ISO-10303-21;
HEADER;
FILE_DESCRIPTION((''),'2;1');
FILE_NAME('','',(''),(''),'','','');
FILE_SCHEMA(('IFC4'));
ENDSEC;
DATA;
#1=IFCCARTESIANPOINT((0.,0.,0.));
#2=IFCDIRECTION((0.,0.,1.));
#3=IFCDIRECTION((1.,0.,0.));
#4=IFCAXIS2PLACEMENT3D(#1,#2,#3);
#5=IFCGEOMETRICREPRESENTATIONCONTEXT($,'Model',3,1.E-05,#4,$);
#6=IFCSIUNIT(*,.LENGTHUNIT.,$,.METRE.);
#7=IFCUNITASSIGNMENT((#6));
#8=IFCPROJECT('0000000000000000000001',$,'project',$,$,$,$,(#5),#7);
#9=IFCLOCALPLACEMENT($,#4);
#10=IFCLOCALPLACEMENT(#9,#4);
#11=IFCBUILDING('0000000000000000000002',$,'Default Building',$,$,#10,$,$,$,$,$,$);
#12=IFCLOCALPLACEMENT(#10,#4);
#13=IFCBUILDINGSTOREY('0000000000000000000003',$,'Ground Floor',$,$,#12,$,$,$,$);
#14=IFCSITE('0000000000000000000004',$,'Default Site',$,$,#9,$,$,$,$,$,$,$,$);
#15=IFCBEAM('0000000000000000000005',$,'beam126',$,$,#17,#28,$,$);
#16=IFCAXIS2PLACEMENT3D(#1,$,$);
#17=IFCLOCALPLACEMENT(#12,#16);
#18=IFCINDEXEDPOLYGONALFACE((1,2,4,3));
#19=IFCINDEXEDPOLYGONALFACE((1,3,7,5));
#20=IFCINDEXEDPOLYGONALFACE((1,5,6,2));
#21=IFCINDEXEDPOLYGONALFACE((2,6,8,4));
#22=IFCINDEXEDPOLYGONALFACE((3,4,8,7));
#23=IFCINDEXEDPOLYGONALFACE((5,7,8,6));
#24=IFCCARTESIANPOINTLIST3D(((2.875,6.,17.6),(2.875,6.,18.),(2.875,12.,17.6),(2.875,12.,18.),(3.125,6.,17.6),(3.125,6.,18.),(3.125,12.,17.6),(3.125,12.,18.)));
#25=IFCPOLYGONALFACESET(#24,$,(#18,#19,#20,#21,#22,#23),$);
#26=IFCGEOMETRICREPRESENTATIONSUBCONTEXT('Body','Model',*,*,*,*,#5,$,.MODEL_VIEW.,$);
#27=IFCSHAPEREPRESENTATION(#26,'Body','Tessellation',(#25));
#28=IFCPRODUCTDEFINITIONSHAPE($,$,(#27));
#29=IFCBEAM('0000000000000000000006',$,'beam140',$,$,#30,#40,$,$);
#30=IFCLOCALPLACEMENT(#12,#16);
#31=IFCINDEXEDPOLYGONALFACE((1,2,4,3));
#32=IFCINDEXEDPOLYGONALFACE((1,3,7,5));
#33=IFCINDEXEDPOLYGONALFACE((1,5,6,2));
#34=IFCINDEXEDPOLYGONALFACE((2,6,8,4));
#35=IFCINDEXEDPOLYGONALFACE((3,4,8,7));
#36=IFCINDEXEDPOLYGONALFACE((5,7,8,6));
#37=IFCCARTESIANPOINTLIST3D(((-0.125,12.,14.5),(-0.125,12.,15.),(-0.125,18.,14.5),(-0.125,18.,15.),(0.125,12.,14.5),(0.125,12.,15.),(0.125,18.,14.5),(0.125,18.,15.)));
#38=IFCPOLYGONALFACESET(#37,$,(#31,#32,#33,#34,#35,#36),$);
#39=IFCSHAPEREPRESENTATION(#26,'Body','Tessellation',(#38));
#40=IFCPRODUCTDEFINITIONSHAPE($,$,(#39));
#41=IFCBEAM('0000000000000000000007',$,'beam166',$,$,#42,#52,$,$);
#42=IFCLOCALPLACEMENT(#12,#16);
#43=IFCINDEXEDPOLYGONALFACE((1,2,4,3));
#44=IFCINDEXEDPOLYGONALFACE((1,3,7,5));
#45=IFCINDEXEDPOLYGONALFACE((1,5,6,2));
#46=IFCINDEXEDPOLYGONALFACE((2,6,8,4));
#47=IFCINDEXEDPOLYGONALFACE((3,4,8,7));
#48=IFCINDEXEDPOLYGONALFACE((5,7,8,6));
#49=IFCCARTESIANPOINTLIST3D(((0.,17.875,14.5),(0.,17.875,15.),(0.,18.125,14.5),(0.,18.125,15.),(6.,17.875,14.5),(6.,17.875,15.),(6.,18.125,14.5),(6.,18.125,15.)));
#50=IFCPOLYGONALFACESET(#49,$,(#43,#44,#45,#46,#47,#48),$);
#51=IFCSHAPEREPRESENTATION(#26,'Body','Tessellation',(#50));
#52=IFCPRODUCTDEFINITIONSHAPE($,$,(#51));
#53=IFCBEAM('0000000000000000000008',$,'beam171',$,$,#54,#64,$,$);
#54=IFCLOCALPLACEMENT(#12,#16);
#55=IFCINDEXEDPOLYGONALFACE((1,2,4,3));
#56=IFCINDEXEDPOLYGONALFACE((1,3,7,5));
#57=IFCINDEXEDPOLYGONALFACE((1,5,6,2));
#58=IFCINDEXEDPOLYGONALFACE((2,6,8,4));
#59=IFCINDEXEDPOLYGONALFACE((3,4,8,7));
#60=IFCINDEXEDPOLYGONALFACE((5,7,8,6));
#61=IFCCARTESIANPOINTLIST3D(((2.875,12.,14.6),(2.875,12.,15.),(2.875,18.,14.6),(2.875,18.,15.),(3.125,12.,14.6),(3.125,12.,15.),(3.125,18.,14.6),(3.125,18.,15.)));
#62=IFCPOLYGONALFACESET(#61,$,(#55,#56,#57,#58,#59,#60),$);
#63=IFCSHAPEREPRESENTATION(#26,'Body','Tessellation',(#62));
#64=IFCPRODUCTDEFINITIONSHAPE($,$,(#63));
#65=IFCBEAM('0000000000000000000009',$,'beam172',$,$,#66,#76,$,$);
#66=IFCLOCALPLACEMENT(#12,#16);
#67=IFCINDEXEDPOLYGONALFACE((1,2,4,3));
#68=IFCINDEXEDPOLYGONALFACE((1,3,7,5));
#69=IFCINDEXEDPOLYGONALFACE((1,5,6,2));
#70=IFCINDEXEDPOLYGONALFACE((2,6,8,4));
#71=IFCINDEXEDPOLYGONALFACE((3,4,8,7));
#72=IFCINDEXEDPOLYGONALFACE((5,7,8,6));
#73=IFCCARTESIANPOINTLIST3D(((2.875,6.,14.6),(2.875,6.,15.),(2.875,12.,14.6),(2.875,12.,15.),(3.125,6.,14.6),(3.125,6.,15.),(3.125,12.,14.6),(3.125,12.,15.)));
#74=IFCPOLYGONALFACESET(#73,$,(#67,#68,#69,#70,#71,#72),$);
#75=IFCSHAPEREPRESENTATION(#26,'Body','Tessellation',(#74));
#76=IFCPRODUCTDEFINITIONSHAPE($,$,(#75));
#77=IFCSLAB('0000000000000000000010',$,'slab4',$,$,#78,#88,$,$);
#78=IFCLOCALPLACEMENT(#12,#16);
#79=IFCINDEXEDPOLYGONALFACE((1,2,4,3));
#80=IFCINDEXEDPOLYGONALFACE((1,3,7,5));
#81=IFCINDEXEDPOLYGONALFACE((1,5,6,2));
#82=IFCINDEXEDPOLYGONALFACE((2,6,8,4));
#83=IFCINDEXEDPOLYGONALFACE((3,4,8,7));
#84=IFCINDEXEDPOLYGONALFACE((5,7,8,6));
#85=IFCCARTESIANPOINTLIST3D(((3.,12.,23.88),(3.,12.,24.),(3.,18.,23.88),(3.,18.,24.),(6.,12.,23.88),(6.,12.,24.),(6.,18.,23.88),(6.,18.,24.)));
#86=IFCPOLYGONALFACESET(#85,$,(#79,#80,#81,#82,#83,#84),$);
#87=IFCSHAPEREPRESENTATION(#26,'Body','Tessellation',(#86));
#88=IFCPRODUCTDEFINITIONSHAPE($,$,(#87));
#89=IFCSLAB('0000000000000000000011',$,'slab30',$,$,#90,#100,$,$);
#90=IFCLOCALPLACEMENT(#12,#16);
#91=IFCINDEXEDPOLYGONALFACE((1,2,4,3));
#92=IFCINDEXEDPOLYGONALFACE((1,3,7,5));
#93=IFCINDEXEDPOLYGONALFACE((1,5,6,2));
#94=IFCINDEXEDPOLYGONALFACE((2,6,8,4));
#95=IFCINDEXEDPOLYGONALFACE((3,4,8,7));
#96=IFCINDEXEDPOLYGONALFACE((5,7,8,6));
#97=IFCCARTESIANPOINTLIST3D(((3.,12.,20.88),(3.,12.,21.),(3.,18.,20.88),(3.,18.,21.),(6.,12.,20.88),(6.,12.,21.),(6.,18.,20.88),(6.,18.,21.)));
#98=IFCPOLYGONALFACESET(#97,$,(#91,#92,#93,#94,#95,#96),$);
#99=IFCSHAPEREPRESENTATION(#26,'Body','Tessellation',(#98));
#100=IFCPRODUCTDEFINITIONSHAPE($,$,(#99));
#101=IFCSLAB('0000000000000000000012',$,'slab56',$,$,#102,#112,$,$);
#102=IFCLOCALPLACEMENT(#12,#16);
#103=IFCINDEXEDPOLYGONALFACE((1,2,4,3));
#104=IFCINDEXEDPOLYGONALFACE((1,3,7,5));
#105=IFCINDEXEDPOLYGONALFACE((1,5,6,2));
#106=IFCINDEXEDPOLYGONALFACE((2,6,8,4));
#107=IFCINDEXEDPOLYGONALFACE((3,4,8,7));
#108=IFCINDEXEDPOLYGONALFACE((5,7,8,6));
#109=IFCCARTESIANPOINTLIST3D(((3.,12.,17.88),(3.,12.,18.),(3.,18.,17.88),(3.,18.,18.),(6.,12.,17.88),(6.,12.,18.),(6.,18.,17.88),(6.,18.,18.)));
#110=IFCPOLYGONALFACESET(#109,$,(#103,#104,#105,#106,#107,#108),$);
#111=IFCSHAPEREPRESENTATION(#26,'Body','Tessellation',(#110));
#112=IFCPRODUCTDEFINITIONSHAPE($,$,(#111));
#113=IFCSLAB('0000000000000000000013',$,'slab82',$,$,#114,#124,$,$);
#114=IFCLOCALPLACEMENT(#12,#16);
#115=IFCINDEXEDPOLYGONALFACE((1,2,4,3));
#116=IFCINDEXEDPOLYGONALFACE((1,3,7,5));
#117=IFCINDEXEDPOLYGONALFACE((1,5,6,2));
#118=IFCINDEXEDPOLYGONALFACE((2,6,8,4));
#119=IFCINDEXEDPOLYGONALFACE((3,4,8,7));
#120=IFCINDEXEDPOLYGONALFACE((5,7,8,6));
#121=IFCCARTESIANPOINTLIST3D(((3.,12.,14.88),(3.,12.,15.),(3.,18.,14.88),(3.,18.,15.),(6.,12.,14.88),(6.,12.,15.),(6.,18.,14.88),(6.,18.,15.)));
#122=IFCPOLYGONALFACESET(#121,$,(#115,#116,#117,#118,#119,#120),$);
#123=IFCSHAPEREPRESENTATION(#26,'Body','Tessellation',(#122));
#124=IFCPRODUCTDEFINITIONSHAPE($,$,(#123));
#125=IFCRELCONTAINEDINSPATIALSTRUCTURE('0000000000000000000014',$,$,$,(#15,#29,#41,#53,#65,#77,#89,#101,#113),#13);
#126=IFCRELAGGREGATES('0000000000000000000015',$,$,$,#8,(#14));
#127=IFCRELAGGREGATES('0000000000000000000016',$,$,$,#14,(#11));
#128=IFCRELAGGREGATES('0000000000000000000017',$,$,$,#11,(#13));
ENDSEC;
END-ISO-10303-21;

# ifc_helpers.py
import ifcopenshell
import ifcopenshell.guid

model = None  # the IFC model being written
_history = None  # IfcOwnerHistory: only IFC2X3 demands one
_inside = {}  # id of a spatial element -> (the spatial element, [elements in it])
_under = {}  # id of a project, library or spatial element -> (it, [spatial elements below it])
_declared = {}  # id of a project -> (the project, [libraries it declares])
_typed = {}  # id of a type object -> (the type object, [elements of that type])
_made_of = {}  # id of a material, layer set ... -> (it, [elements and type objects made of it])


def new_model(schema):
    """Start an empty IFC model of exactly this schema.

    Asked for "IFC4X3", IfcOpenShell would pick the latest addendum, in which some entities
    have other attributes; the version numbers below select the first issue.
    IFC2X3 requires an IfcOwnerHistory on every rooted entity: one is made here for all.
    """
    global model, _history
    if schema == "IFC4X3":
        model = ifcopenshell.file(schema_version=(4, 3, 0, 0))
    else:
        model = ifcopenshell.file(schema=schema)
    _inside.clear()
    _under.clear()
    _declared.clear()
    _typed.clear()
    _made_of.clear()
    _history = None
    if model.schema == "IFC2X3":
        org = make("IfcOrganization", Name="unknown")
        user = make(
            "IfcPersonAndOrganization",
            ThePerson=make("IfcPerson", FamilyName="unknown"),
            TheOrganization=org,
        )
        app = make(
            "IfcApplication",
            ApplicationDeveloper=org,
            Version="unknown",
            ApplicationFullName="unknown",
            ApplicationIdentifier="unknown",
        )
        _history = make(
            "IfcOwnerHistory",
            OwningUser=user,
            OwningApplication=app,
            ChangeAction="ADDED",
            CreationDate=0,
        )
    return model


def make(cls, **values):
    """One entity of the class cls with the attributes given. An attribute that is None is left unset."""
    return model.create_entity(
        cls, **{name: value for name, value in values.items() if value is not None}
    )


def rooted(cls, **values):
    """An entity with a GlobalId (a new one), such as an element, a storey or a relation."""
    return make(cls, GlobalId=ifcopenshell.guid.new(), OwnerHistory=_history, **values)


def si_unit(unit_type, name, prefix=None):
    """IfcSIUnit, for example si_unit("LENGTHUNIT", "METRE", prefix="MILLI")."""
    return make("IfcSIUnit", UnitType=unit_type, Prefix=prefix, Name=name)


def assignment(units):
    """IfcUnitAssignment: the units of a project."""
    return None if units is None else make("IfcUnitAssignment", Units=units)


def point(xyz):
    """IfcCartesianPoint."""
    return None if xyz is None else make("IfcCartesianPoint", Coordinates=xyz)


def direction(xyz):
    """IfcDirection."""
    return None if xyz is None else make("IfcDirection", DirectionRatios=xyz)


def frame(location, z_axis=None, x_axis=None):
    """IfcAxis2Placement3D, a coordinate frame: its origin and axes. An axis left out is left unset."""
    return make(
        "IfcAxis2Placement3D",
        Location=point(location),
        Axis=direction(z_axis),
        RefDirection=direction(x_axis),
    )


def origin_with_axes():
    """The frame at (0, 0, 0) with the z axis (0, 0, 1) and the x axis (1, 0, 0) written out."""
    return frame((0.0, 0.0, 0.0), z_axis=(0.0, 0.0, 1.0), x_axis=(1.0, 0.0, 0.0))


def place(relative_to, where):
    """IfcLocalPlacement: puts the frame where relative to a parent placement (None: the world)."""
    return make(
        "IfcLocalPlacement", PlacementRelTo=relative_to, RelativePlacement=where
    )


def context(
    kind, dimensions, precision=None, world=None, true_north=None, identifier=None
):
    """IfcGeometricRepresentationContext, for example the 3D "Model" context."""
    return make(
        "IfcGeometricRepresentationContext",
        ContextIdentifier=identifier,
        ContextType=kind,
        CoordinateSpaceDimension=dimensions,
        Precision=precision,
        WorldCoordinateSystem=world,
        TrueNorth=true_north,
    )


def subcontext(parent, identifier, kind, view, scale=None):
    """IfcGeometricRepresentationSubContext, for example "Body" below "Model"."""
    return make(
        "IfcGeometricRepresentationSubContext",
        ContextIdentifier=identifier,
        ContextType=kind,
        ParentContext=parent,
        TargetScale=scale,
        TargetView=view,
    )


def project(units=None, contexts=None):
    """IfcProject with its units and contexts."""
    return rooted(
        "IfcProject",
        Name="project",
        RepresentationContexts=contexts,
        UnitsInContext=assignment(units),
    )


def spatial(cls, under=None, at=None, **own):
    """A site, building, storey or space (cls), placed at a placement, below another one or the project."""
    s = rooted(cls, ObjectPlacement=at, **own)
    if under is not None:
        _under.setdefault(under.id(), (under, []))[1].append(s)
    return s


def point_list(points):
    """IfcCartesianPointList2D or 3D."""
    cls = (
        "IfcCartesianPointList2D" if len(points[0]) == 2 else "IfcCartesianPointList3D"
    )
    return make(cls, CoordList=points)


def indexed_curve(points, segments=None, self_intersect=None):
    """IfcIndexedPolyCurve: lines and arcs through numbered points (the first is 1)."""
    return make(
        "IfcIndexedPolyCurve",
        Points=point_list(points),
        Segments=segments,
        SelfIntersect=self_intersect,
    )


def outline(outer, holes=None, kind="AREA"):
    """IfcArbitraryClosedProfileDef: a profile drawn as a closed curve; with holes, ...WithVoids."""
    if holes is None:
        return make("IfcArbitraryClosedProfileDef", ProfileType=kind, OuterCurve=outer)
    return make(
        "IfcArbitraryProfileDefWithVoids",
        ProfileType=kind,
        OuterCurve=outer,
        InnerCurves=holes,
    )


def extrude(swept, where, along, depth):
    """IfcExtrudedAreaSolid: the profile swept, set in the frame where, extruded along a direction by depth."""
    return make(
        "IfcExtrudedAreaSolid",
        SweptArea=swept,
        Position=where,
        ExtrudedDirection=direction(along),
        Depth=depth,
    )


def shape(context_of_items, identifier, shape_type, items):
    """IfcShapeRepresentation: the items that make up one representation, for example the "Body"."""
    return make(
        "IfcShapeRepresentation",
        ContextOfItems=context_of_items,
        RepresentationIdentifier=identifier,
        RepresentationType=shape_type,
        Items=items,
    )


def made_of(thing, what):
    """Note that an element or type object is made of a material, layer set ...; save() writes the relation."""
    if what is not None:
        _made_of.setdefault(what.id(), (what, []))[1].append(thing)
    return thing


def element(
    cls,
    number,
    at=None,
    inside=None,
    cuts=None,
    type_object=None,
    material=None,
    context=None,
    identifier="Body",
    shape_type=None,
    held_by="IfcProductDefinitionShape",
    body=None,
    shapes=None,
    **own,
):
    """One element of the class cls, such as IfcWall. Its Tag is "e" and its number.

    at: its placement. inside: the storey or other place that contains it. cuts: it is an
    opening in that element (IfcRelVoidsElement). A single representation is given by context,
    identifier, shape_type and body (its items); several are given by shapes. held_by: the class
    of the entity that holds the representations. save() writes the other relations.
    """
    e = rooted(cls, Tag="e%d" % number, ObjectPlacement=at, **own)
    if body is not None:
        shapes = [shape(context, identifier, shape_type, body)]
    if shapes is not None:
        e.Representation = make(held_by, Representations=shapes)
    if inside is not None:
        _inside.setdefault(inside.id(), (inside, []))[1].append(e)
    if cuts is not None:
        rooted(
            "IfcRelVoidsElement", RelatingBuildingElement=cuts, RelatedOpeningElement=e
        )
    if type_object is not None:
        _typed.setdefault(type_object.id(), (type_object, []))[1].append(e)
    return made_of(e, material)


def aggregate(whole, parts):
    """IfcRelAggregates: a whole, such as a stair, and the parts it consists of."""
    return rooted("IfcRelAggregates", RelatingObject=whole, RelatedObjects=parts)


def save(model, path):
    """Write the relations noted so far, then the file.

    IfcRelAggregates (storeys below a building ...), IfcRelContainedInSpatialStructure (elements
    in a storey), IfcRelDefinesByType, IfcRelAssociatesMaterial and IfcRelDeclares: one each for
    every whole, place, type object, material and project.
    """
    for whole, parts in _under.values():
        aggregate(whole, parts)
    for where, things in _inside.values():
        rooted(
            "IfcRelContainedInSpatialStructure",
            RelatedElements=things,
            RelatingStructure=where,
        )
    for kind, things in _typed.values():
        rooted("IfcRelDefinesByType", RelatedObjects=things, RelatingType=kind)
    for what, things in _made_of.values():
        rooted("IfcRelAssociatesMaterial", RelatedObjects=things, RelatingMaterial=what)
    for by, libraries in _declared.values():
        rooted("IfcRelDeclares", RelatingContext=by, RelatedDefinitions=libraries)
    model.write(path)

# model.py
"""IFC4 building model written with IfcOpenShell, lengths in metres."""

from ifc_helpers import new_model, si_unit, frame, origin_with_axes, place, context, subcontext, project, spatial, indexed_curve, outline, extrude, element, save


model = new_model("IFC4")

# Units and contexts
model_context = context("Model", 3, precision=1e-05, world=origin_with_axes())
body_context = subcontext(model_context, "Body", "Model", "MODEL_VIEW")
ifc_project = project(units=[si_unit("LENGTHUNIT", "METRE")], contexts=[model_context])

# Site, building, storey
site_placement = place(None, origin_with_axes())
site = spatial("IfcSite", under=ifc_project, at=site_placement, Name="Default Site")
building_placement = place(site_placement, origin_with_axes())
building = spatial("IfcBuilding", under=site, at=building_placement, Name="Default Building")
storey_placement = place(building_placement, origin_with_axes())
storey = spatial("IfcBuildingStorey", under=building, at=storey_placement, Name="Ground Floor")

# Beams
for number, where, z_axis, x_axis, name in (
    (1, (2.875, 12.0, 17.6), (0.0, 0.0, 1.0), (0.0, -1.0, 0.0), "beam126"),
):
    element("IfcBeam", number, at=place(storey_placement, frame(where, z_axis=z_axis, x_axis=x_axis)), inside=storey, Name=name, context=body_context, shape_type="SweptSolid", body=[
        extrude(outline(indexed_curve([(0.0, 0.0), (0.0, 0.25), (6.0, 0.25), (6.0, 0.0), (0.0, 0.0)], self_intersect=False)), origin_with_axes(), (0.0, 0.0, 1.0), 0.4),
    ])
for number, where, z_axis, x_axis, name in (
    (2, (0.125, 12.0, 14.5), (0.0, 0.0, 1.0), (0.0, 1.0, 0.0), "beam140"),
    (3, (0.0, 17.875, 14.5), (0.0, 0.0, 1.0), (1.0, 0.0, 0.0), "beam166"),
):
    element("IfcBeam", number, at=place(storey_placement, frame(where, z_axis=z_axis, x_axis=x_axis)), inside=storey, Name=name, context=body_context, shape_type="SweptSolid", body=[
        extrude(outline(indexed_curve([(0.0, 0.0), (0.0, 0.25), (6.0, 0.25), (6.0, 0.0), (0.0, 0.0)], self_intersect=False)), origin_with_axes(), (0.0, 0.0, 1.0), 0.5),
    ])
for number, where, z_axis, x_axis, name in (
    (4, (2.875, 18.0, 14.6), (0.0, 0.0, 1.0), (0.0, -1.0, 0.0), "beam171"),
    (5, (2.875, 12.0, 14.6), (0.0, 0.0, 1.0), (0.0, -1.0, 0.0), "beam172"),
):
    element("IfcBeam", number, at=place(storey_placement, frame(where, z_axis=z_axis, x_axis=x_axis)), inside=storey, Name=name, context=body_context, shape_type="SweptSolid", body=[
        extrude(outline(indexed_curve([(0.0, 0.0), (0.0, 0.25), (6.0, 0.25), (6.0, 0.0), (0.0, 0.0)], self_intersect=False)), origin_with_axes(), (0.0, 0.0, 1.0), 0.4),
    ])

# Slabs
for number, where, z_axis, x_axis, name in (
    (6, (3.0, 12.0, 23.88), (0.0, 0.0, 1.0), (1.0, 0.0, 0.0), "slab4"),
    (7, (3.0, 12.0, 20.88), (0.0, 0.0, 1.0), (1.0, 0.0, 0.0), "slab30"),
    (8, (3.0, 12.0, 17.88), (0.0, 0.0, 1.0), (1.0, 0.0, 0.0), "slab56"),
    (9, (3.0, 12.0, 14.88), (0.0, 0.0, 1.0), (1.0, 0.0, 0.0), "slab82"),
):
    element("IfcSlab", number, at=place(storey_placement, frame(where, z_axis=z_axis, x_axis=x_axis)), inside=storey, Name=name, context=body_context, shape_type="SweptSolid", body=[
        extrude(outline(indexed_curve([(0.0, 0.0), (0.0, 6.0), (3.0, 6.0), (3.0, 0.0), (0.0, 0.0)], self_intersect=False)), origin_with_axes(), (0.0, 0.0, 1.0), 0.12),
    ])

save(model, "model.ifc")
